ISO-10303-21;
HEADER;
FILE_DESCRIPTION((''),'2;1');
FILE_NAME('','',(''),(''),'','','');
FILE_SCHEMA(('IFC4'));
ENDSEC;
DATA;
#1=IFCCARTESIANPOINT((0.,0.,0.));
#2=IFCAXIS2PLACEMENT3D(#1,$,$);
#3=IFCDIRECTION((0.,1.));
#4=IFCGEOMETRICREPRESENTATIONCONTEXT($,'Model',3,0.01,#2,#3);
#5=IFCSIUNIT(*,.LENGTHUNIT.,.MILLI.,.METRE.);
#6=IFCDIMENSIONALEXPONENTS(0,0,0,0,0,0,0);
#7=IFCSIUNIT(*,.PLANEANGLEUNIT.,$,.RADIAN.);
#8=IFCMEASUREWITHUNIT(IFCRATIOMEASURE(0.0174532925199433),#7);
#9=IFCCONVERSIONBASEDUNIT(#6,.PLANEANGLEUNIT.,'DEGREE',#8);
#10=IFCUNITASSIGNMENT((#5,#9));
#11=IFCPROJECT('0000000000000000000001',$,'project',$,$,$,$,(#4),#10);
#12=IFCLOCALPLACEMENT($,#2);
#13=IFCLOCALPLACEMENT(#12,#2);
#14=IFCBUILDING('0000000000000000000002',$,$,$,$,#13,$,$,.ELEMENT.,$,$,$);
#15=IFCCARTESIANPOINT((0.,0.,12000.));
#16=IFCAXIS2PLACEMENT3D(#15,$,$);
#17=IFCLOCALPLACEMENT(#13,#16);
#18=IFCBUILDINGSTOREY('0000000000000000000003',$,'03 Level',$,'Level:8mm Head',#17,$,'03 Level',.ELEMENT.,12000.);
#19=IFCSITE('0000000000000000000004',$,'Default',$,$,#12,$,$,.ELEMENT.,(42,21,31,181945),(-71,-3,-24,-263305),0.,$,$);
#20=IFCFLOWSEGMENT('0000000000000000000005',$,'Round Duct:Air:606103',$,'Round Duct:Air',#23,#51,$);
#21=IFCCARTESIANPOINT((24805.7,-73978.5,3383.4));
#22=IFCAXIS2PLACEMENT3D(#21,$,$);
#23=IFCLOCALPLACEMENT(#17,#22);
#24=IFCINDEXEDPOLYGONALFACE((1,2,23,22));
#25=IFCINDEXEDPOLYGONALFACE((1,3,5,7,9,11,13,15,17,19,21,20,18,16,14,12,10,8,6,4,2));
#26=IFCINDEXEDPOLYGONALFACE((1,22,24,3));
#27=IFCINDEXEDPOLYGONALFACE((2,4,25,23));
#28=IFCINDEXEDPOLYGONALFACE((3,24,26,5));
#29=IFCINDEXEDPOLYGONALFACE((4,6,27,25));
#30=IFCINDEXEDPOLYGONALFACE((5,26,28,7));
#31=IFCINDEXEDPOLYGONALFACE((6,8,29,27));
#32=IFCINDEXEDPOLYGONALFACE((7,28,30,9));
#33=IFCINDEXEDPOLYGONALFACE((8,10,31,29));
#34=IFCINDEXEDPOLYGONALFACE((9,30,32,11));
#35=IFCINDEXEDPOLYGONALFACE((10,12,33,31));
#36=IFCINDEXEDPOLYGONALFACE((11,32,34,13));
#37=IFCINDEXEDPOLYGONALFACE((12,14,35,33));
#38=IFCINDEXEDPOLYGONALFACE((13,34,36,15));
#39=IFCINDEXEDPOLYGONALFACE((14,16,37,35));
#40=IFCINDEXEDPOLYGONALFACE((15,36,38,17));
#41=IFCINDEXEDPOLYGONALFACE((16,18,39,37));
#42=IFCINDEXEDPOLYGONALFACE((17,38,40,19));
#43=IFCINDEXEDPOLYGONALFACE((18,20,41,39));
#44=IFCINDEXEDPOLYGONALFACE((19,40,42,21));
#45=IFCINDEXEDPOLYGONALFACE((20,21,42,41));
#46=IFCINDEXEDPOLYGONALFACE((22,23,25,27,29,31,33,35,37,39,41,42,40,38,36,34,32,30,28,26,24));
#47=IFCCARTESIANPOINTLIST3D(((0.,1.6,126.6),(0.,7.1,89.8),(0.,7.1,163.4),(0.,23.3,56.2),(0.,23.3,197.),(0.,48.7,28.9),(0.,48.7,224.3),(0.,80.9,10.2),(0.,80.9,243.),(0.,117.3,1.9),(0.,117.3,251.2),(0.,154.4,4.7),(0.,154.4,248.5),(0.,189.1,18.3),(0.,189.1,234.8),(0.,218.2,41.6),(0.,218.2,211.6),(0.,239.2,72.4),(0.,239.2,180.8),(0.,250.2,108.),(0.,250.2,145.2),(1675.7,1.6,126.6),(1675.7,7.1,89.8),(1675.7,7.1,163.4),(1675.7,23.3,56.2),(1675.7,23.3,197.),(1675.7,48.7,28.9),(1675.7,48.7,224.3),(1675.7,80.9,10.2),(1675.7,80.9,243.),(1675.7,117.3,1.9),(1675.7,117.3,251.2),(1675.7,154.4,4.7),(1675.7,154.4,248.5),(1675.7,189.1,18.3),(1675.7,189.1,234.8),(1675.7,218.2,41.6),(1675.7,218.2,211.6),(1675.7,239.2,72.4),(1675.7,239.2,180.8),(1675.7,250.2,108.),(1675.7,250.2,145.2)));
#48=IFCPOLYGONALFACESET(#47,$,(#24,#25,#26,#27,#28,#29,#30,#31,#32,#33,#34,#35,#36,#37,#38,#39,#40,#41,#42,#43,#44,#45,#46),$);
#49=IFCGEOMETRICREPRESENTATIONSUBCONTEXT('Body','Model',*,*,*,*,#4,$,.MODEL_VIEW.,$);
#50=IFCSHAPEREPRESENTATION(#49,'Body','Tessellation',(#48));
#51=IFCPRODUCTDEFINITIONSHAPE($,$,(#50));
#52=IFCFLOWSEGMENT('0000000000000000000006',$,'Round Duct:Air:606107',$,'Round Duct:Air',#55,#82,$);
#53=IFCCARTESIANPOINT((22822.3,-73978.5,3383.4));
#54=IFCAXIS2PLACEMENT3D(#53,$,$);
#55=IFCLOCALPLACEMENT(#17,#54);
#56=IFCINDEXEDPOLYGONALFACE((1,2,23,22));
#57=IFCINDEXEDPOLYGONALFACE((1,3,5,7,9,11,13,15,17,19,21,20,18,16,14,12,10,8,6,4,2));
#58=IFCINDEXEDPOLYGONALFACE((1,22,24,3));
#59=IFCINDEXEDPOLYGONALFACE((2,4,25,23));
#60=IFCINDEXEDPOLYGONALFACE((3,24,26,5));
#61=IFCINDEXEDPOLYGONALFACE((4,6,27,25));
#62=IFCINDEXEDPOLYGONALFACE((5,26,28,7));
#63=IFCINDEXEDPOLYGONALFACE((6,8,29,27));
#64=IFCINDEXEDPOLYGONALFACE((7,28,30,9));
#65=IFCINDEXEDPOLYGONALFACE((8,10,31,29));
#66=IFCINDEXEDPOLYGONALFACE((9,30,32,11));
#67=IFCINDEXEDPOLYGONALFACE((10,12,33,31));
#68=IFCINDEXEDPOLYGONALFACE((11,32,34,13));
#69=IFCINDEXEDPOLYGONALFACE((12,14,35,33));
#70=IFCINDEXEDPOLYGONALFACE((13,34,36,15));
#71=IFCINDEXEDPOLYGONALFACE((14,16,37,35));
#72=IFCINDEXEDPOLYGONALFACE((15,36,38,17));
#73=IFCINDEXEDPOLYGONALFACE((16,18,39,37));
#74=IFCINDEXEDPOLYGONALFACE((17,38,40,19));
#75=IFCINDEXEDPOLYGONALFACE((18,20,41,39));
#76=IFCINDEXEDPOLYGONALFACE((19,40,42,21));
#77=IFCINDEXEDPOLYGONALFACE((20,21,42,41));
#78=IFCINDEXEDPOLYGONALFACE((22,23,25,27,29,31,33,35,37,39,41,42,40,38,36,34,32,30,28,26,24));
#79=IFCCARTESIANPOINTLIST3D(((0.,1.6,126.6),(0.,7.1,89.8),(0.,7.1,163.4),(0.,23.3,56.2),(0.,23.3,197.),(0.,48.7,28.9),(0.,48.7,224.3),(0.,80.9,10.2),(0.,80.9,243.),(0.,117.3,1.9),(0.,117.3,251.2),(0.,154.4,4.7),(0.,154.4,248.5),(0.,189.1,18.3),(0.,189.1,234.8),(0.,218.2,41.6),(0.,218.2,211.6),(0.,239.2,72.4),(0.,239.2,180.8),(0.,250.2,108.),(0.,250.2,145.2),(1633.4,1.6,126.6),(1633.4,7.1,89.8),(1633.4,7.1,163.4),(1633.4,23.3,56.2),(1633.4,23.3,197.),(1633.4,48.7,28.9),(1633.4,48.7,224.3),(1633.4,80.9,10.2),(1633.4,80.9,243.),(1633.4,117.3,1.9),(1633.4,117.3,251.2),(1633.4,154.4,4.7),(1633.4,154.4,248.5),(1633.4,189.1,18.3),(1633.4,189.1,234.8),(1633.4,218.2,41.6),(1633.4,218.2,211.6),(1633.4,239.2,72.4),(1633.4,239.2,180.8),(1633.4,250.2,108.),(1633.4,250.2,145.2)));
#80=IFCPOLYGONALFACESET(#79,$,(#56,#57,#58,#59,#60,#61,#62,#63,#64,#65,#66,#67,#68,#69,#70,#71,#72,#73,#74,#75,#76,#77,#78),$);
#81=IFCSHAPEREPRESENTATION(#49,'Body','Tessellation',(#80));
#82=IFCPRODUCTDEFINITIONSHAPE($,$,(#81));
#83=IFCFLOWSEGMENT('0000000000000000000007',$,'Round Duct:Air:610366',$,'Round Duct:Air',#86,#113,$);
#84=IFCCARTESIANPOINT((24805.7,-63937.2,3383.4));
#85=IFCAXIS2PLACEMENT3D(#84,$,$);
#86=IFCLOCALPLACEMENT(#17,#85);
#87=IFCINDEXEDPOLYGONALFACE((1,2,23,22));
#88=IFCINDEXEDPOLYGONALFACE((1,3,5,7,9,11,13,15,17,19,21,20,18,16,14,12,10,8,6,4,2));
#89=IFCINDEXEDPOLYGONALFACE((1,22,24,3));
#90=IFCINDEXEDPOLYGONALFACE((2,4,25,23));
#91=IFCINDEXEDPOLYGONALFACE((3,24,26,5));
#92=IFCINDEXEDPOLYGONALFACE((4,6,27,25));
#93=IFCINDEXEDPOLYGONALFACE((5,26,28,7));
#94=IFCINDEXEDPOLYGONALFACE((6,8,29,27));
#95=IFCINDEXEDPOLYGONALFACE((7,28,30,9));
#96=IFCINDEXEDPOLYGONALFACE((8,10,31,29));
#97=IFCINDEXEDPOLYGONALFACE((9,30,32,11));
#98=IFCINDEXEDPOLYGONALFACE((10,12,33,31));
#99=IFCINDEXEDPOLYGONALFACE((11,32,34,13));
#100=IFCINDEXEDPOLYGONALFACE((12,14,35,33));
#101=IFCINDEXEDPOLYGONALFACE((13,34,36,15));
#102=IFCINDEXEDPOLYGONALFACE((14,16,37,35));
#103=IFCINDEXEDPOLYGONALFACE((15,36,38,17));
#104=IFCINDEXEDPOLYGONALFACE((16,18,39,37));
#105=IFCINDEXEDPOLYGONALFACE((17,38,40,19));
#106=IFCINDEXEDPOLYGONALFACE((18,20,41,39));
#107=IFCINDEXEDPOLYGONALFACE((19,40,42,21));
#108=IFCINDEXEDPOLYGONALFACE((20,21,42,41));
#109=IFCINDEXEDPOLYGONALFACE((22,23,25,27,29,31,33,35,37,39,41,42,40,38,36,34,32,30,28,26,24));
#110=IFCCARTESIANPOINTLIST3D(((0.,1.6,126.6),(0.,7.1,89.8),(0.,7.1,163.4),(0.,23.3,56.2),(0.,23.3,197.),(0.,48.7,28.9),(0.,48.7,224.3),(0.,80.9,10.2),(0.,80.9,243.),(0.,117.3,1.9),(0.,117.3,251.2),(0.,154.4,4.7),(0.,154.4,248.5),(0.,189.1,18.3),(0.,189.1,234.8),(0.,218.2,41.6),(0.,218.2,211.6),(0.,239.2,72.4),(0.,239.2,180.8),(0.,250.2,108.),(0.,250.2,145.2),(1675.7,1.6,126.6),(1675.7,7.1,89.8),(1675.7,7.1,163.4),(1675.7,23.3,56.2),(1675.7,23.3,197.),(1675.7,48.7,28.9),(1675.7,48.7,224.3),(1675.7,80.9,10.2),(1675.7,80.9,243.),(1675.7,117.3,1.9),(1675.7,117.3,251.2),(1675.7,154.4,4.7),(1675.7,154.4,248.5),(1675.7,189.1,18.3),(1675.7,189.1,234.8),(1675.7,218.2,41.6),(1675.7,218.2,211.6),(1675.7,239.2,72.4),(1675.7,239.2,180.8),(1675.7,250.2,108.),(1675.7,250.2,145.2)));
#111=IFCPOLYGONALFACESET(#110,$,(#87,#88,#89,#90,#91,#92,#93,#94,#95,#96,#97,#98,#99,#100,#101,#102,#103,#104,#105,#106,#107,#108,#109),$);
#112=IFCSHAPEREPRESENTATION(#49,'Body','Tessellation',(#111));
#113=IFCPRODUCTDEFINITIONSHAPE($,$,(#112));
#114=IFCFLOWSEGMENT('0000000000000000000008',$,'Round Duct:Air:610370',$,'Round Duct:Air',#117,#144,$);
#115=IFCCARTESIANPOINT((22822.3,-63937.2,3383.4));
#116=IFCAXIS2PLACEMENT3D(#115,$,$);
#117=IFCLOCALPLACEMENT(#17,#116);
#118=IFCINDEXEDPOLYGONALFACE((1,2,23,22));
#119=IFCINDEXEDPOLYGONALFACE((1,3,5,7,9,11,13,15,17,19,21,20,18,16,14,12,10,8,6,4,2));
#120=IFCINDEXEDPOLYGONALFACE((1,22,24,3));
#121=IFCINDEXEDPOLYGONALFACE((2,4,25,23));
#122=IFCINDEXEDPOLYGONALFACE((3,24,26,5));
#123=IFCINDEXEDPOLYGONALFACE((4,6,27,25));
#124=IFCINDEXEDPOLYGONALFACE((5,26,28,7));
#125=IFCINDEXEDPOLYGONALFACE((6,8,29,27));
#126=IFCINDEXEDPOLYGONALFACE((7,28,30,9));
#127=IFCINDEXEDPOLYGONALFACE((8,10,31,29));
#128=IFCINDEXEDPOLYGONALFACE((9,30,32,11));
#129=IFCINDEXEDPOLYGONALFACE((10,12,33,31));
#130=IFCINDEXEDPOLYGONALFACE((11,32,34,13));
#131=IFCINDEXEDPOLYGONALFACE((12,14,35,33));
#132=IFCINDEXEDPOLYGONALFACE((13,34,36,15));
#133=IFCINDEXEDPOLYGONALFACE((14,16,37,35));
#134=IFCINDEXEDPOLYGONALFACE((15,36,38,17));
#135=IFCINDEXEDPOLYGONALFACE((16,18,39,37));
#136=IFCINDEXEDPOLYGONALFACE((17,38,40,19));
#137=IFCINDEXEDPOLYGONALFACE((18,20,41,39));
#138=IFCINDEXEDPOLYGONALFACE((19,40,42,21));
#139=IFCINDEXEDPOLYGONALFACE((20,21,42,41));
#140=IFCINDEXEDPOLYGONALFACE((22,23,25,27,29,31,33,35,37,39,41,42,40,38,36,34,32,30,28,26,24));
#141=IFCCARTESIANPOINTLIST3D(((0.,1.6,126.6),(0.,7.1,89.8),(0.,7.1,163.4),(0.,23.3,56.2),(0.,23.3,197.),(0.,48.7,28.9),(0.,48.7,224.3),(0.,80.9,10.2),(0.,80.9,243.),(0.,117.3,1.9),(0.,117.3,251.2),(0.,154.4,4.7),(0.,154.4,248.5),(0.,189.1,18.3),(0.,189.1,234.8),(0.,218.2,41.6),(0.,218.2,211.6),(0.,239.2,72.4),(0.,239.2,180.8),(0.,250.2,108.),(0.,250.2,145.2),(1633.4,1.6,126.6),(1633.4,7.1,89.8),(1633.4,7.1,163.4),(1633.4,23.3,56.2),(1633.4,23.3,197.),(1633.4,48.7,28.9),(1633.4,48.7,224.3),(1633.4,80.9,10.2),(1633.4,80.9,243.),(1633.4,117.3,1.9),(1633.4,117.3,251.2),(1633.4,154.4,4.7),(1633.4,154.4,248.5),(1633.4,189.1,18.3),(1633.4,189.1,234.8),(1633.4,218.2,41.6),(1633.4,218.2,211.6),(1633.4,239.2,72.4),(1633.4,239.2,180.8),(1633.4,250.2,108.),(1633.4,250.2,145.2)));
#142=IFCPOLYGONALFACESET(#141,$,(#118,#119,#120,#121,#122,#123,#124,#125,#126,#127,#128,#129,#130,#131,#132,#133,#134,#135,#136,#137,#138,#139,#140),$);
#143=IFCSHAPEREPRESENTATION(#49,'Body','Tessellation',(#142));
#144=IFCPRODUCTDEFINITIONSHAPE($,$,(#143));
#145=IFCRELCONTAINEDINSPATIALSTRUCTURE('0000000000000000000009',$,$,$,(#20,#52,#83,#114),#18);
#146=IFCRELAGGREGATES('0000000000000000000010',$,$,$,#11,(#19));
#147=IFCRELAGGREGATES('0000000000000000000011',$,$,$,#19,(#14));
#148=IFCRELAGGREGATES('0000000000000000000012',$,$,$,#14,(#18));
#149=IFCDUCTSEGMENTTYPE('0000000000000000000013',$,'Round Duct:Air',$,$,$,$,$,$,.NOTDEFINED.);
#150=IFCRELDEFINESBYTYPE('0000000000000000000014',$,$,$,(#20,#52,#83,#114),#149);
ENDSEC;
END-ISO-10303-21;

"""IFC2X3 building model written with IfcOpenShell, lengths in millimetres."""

from ifc_helpers import new_model, entity, si_unit, converted_unit, direction, frame, origin, origin_2d_with_axis, place, context, subcontext, project, spatial, circle, extrude, type_object, element, save


model = new_model("IFC2X3")

# Units and contexts
model_context = context("Model", 3, precision=0.01, world=origin(), true_north=direction((0.0, 1.0)))
body_context = subcontext(model_context, "Body", "Model", "MODEL_VIEW")
ifc_project = project(units=[si_unit("LENGTHUNIT", "METRE", prefix="MILLI"), converted_unit("PLANEANGLEUNIT", "DEGREE", entity("IfcRatioMeasure", 0.0174532925199433), si_unit("PLANEANGLEUNIT", "RADIAN"), dimensions=[0, 0, 0, 0, 0, 0, 0])], contexts=[model_context])

# Site, building, storey
site_placement = place(None, origin())
site = spatial("IfcSite", under=ifc_project, at=site_placement, Name="Default", CompositionType="ELEMENT", RefLatitude=(42, 21, 31, 181945), RefLongitude=(-71, -3, -24, -263305), RefElevation=0.0)
building_placement = place(site_placement, origin())
building = spatial("IfcBuilding", under=site, at=building_placement, CompositionType="ELEMENT")
storey_placement = place(building_placement, frame((0.0, 0.0, 12000.0)))
storey = spatial("IfcBuildingStorey", under=building, at=storey_placement, Name="03 Level", ObjectType="Level:8mm Head", LongName="03 Level", CompositionType="ELEMENT", Elevation=12000.0)

# Flow segments
duct_segment_type_1 = type_object("IfcDuctSegmentType", Name="Round Duct:Air", PredefinedType="NOTDEFINED")
flow_segment_1_placement = place(storey_placement, frame((24805.7, -73978.5, 3383.4)))
element("IfcFlowSegment", 1, at=flow_segment_1_placement, inside=storey, type_object=duct_segment_type_1, Name="Round Duct:Air:606103", ObjectType="Round Duct:Air", context=body_context, shape_type="SweptSolid", body=[
    extrude(circle(Radius=125.0, at=origin_2d_with_axis()), frame((0.0, 126.6, 126.6), z_axis=(1.0, 0.0, 0.0), x_axis=(0.0, -1.0, 0.0)), (0.0, 0.0, 1.0), 1675.7),
])
flow_segment_2_placement = place(storey_placement, frame((22822.3, -73978.5, 3383.4)))
element("IfcFlowSegment", 2, at=flow_segment_2_placement, inside=storey, type_object=duct_segment_type_1, Name="Round Duct:Air:606107", ObjectType="Round Duct:Air", context=body_context, shape_type="SweptSolid", body=[
    extrude(circle(Radius=125.0, at=origin_2d_with_axis()), frame((0.0, 126.6, 126.6), z_axis=(1.0, 0.0, 0.0), x_axis=(0.0, -1.0, 0.0)), (0.0, 0.0, 1.0), 1633.4),
])
flow_segment_3_placement = place(storey_placement, frame((24805.7, -63937.2, 3383.4)))
element("IfcFlowSegment", 3, at=flow_segment_3_placement, inside=storey, type_object=duct_segment_type_1, Name="Round Duct:Air:610366", ObjectType="Round Duct:Air", context=body_context, shape_type="SweptSolid", body=[
    extrude(circle(Radius=125.0, at=origin_2d_with_axis()), frame((0.0, 126.6, 126.6), z_axis=(1.0, 0.0, 0.0), x_axis=(0.0, -1.0, 0.0)), (0.0, 0.0, 1.0), 1675.7),
])
flow_segment_4_placement = place(storey_placement, frame((22822.3, -63937.2, 3383.4)))
element("IfcFlowSegment", 4, at=flow_segment_4_placement, inside=storey, type_object=duct_segment_type_1, Name="Round Duct:Air:610370", ObjectType="Round Duct:Air", context=body_context, shape_type="SweptSolid", body=[
    extrude(circle(Radius=125.0, at=origin_2d_with_axis()), frame((0.0, 126.6, 126.6), z_axis=(1.0, 0.0, 0.0), x_axis=(0.0, -1.0, 0.0)), (0.0, 0.0, 1.0), 1633.4),
])

save(model, "model.ifc")
